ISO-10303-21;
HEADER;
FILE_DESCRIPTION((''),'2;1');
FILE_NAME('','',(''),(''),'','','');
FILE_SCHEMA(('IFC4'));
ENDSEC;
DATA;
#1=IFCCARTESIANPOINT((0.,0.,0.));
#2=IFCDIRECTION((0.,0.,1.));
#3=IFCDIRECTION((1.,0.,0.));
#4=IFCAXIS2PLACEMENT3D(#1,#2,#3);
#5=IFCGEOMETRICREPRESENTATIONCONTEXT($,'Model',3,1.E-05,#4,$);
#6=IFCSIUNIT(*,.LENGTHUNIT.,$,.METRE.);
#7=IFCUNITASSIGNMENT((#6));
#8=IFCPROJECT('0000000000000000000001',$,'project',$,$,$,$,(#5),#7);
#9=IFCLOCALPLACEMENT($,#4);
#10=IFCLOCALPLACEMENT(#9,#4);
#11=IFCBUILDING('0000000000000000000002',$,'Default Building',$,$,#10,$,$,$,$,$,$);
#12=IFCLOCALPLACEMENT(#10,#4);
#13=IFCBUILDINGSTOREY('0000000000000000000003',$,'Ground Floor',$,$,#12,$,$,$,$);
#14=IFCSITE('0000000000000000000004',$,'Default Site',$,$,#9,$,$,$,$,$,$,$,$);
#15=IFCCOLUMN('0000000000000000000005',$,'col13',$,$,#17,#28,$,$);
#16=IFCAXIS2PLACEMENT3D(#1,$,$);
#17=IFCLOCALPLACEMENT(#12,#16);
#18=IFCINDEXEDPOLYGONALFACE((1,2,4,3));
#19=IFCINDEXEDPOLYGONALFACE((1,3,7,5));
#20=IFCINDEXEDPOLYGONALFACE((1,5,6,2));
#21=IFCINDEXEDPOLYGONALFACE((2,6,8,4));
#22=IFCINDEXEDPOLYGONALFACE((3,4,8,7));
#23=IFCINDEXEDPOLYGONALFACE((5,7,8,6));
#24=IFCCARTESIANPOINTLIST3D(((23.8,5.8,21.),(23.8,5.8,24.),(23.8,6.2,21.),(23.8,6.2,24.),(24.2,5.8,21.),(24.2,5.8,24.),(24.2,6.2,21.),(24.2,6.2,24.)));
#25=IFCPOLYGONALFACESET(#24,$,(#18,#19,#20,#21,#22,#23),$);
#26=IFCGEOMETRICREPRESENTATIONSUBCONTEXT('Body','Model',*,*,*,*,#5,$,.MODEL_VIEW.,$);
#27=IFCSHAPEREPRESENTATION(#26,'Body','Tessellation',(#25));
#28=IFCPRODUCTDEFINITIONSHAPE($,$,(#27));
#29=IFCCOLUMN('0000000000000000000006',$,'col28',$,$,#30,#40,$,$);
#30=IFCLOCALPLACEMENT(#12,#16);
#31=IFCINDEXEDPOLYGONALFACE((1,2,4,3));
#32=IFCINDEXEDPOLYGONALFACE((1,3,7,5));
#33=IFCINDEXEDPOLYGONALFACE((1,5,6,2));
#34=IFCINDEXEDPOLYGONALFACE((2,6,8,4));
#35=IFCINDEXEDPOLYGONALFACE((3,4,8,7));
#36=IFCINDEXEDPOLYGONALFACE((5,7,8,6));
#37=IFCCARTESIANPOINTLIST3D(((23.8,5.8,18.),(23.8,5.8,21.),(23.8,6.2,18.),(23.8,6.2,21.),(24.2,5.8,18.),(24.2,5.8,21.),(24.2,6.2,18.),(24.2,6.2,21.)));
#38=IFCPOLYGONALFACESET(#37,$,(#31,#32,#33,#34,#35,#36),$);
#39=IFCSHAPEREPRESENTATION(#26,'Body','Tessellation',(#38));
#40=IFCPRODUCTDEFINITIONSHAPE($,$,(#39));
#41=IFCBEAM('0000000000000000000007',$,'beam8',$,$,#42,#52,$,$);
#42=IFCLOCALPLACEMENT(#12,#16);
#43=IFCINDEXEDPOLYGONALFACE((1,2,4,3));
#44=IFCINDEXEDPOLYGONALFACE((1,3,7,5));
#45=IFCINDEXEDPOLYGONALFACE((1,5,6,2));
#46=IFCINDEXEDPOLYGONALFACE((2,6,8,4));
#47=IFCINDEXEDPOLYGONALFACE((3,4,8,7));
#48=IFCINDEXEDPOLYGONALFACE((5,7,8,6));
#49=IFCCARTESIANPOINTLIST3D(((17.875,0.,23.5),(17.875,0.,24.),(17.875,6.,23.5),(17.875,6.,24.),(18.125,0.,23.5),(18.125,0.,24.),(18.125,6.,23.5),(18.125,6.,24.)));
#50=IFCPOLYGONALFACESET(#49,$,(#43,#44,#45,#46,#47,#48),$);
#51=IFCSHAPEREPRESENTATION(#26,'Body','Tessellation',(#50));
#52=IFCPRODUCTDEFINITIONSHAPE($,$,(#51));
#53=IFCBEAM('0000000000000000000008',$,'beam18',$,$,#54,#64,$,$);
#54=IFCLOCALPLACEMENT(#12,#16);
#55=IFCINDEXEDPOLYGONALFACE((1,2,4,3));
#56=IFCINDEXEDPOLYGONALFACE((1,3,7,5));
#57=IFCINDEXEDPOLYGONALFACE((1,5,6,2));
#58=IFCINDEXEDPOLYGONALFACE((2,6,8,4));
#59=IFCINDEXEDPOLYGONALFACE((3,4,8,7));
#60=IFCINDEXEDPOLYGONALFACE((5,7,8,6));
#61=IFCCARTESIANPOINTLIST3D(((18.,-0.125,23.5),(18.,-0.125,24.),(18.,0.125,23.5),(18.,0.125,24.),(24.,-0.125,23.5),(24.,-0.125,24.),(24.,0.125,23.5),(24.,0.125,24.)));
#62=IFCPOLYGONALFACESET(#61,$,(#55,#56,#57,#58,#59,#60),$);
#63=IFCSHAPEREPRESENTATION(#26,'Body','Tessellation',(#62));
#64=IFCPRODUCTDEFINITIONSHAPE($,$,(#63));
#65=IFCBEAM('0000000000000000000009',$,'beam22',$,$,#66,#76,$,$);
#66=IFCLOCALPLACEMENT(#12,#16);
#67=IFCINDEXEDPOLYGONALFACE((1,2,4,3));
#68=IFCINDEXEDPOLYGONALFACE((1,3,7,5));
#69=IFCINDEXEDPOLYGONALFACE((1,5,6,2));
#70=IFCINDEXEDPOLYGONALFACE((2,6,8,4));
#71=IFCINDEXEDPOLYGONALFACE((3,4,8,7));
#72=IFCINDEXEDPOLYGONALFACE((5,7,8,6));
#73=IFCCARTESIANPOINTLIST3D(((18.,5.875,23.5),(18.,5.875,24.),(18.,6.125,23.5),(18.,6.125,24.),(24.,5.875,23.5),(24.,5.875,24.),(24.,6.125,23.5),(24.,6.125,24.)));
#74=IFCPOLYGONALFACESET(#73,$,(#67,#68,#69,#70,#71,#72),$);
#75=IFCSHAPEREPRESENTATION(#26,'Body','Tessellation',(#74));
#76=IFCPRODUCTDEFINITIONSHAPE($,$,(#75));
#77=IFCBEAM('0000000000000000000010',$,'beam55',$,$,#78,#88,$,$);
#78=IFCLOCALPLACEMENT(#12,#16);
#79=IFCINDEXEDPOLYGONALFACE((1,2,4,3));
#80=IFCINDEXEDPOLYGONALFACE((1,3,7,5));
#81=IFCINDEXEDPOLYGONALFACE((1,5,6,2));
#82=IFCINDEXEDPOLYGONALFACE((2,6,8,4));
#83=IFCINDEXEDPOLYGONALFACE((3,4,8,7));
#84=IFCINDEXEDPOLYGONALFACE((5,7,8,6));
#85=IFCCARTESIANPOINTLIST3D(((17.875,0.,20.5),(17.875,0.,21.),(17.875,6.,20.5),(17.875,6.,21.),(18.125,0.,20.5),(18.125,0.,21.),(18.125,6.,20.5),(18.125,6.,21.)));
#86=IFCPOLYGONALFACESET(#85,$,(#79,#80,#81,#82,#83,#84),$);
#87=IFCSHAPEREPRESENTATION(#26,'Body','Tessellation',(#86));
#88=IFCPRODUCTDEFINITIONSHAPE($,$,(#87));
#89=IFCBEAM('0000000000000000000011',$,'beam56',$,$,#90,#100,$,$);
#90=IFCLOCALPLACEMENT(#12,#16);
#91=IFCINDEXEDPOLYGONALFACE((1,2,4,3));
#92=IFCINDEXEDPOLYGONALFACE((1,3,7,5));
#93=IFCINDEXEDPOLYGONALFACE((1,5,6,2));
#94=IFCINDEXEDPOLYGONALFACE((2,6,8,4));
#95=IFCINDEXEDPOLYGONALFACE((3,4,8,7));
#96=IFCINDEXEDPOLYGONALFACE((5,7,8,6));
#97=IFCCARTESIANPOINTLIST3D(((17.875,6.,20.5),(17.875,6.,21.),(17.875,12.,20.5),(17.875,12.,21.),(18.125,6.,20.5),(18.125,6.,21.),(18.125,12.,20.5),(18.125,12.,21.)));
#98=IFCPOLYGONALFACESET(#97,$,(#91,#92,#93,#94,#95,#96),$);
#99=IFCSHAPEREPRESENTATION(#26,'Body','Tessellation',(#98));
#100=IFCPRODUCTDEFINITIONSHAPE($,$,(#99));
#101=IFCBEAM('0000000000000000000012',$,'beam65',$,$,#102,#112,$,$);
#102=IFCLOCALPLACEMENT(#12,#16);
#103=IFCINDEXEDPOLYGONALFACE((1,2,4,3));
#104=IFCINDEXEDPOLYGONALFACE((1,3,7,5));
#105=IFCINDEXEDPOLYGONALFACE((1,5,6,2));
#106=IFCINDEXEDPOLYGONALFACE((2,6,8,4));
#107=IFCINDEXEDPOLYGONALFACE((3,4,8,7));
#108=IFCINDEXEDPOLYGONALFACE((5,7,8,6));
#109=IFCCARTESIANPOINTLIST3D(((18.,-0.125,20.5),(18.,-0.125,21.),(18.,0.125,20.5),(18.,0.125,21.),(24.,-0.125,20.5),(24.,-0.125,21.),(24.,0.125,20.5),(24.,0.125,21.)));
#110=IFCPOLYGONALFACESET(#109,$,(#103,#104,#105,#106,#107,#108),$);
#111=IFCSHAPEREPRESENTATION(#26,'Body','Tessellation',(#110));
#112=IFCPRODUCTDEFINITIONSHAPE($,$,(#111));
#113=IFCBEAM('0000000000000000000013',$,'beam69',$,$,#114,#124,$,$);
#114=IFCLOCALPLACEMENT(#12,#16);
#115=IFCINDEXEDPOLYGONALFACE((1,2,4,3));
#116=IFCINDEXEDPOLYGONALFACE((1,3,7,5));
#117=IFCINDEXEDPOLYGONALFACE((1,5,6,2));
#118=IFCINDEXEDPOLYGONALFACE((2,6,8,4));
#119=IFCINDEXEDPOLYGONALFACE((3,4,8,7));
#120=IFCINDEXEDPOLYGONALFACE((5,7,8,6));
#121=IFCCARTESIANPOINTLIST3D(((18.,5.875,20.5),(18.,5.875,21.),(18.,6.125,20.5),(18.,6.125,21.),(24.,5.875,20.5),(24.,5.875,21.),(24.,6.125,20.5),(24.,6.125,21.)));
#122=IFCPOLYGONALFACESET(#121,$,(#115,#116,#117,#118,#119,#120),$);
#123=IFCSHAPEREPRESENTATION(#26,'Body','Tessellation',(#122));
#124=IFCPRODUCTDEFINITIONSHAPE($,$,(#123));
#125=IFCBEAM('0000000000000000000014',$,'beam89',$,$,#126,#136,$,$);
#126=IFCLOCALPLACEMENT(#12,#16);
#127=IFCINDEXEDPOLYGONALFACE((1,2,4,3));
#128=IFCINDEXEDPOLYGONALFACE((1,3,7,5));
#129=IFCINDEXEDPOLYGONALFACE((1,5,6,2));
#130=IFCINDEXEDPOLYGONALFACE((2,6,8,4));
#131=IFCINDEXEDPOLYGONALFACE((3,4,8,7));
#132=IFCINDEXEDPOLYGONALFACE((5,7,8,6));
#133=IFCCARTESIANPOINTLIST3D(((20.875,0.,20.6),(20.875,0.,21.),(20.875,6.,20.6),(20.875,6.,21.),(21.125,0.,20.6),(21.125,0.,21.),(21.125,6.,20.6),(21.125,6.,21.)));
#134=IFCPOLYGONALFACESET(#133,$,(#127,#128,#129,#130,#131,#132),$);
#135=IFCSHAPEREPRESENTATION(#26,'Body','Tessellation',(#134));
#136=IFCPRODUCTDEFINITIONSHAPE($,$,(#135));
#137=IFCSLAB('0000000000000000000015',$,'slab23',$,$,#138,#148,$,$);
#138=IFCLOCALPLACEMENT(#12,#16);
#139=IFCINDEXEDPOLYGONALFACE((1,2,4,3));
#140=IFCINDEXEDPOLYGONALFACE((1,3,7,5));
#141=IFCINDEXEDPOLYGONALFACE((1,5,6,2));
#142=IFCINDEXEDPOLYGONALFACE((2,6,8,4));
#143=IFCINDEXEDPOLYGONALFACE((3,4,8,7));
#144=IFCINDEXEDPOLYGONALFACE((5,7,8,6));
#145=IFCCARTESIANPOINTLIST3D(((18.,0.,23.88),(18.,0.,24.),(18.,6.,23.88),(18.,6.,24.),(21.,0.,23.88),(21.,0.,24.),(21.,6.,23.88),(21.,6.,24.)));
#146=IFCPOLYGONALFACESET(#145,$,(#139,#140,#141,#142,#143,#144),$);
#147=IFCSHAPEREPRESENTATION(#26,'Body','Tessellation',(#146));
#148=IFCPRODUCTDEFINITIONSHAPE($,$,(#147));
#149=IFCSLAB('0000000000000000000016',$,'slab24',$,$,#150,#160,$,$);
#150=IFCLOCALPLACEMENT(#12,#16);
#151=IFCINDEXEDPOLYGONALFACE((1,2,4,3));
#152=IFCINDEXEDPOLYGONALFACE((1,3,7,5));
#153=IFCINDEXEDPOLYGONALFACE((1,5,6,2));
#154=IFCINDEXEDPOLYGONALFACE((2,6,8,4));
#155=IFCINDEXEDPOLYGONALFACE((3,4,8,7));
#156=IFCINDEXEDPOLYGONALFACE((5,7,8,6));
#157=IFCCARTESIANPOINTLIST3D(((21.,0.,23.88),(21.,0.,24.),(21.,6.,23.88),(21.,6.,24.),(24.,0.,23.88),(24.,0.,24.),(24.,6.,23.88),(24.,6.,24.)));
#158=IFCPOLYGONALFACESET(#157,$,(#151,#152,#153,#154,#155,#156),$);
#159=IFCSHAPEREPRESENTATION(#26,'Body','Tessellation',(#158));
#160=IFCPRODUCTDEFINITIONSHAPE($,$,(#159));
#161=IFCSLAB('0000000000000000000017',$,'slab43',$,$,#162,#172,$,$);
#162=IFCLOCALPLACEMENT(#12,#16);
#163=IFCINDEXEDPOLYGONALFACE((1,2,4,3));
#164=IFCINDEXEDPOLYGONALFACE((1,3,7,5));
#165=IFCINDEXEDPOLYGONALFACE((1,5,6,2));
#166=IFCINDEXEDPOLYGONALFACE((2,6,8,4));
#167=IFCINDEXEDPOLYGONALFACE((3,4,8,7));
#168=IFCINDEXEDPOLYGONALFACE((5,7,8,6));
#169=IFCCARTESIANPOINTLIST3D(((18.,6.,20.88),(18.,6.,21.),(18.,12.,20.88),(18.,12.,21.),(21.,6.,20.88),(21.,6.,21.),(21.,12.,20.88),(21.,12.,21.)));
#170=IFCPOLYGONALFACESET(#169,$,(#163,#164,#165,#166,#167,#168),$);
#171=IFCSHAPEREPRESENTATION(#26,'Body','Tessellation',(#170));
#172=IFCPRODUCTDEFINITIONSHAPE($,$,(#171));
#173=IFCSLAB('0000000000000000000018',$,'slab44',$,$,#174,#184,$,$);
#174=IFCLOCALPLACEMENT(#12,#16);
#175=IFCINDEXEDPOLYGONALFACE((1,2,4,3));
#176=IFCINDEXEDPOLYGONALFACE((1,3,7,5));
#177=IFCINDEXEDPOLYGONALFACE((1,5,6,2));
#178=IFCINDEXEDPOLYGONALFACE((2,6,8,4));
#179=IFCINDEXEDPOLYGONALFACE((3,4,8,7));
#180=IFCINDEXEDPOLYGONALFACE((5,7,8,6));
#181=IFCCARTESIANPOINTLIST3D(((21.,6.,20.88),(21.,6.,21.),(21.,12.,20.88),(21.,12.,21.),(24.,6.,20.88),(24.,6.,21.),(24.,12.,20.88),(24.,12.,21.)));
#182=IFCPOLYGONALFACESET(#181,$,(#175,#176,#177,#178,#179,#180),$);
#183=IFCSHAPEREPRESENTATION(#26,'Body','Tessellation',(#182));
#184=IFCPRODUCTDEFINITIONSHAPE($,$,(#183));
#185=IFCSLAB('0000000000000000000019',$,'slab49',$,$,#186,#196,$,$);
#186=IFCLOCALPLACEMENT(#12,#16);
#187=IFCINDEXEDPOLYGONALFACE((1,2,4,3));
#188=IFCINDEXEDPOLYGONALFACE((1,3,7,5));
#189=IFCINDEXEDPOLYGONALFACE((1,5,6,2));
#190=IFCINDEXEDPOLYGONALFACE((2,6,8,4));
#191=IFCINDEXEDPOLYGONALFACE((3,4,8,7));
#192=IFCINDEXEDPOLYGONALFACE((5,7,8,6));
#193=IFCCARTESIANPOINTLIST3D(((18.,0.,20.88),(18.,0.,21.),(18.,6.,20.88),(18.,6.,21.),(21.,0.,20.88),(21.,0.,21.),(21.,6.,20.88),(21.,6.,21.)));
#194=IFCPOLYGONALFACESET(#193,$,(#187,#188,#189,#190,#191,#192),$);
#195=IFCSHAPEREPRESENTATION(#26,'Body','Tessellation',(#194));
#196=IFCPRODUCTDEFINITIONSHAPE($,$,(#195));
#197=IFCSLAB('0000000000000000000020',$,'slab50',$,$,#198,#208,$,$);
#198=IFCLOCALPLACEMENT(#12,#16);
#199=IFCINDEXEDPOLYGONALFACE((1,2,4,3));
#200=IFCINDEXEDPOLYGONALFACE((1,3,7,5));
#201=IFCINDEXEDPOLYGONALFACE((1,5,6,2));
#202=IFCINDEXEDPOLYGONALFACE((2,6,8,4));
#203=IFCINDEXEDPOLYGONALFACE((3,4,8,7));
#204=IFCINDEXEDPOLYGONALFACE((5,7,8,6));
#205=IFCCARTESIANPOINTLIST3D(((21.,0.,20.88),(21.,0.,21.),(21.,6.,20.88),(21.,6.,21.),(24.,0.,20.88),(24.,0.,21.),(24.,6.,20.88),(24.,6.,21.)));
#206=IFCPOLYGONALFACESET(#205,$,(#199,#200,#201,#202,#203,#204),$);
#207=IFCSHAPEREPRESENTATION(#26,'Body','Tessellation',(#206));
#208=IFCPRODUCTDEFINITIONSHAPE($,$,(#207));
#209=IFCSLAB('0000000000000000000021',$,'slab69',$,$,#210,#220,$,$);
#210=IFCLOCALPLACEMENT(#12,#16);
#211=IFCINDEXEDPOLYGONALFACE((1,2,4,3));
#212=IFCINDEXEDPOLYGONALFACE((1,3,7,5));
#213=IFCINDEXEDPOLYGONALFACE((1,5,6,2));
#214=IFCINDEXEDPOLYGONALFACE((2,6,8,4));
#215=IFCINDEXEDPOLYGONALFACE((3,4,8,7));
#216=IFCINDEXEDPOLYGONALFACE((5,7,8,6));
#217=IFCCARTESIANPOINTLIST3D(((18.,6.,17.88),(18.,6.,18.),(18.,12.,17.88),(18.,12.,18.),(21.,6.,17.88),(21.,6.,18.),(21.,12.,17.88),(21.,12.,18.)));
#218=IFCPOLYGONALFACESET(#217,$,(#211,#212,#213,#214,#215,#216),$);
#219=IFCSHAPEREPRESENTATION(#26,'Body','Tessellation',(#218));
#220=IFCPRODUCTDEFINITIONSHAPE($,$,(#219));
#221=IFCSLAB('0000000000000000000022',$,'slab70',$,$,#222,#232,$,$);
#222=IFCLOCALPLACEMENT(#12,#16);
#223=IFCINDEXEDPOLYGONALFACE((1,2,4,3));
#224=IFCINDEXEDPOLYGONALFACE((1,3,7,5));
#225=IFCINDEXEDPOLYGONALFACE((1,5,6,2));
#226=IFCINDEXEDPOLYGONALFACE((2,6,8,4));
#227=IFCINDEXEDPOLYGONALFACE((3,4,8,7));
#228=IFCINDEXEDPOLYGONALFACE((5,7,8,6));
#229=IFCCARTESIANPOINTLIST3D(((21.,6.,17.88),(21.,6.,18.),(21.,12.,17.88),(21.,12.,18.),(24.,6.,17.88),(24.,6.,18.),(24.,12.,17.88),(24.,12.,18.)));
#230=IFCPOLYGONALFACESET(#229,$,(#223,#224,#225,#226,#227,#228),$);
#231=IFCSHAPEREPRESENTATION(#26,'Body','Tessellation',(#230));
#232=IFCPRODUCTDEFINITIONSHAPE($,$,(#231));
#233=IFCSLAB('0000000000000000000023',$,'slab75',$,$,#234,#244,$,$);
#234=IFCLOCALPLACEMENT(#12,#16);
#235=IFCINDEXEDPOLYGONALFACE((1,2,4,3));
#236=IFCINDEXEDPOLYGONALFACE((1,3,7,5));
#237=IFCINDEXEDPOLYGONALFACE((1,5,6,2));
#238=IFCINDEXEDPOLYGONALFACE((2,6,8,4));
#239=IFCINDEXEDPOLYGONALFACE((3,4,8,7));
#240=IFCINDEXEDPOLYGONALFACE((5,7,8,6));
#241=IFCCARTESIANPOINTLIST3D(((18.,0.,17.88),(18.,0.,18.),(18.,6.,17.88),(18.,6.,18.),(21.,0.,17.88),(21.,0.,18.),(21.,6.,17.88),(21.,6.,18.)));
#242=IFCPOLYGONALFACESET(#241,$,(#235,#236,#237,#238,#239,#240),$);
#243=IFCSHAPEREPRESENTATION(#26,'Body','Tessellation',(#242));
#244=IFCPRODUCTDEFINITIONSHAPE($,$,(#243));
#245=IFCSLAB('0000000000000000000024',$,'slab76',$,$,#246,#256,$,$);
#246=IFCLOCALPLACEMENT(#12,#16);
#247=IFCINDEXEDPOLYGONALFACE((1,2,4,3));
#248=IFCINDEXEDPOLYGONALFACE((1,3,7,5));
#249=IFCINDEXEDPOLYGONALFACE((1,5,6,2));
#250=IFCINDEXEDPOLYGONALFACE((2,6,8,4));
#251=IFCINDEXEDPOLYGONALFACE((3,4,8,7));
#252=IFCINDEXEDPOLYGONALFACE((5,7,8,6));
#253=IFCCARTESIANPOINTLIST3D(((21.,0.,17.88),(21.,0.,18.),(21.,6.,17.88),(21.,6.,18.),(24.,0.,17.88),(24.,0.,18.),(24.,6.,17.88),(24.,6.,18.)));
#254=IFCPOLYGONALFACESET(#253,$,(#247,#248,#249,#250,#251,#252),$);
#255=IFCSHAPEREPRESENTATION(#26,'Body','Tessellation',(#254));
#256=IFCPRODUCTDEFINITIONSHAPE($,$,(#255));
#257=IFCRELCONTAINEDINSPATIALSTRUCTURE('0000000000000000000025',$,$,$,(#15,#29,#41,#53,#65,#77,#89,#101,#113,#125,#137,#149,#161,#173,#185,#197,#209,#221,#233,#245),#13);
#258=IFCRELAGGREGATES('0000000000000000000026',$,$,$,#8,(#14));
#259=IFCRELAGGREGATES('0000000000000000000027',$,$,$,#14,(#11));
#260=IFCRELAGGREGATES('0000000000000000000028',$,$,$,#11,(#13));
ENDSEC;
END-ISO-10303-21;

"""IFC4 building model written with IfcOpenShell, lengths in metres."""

from ifc_helpers import new_model, si_unit, frame, origin_with_axes, place, context, subcontext, project, spatial, indexed_curve, outline, extrude, element, save


model = new_model("IFC4")

# Units and contexts
model_context = context("Model", 3, precision=1e-05, world=origin_with_axes())
body_context = subcontext(model_context, "Body", "Model", "MODEL_VIEW")
ifc_project = project(units=[si_unit("LENGTHUNIT", "METRE")], contexts=[model_context])

# Site, building, storey
site_placement = place(None, origin_with_axes())
site = spatial("IfcSite", under=ifc_project, at=site_placement, Name="Default Site")
building_placement = place(site_placement, origin_with_axes())
building = spatial("IfcBuilding", under=site, at=building_placement, Name="Default Building")
storey_placement = place(building_placement, origin_with_axes())
storey = spatial("IfcBuildingStorey", under=building, at=storey_placement, Name="Ground Floor")

# Columns
for number, where, z_axis, x_axis, name in (
    (1, (23.8, 5.8, 21.0), (0.0, 0.0, 1.0), (1.0, 0.0, 0.0), "col13"),
    (2, (23.8, 5.8, 18.0), (0.0, 0.0, 1.0), (1.0, 0.0, 0.0), "col28"),
):
    element("IfcColumn", number, at=place(storey_placement, frame(where, z_axis=z_axis, x_axis=x_axis)), inside=storey, Name=name, context=body_context, shape_type="SweptSolid", body=[
        extrude(outline(indexed_curve([(0.0, 0.0), (0.0, 0.4), (0.4, 0.4), (0.4, 0.0), (0.0, 0.0)], self_intersect=False)), origin_with_axes(), (0.0, 0.0, 1.0), 3.0),
    ])

# Beams
for number, where, z_axis, x_axis, name in (
    (3, (18.125, 0.0, 23.5), (0.0, 0.0, 1.0), (0.0, 1.0, 0.0), "beam8"),
    (4, (18.0, -0.125, 23.5), (0.0, 0.0, 1.0), (1.0, 0.0, 0.0), "beam18"),
    (5, (18.0, 5.875, 23.5), (0.0, 0.0, 1.0), (1.0, 0.0, 0.0), "beam22"),
    (6, (18.125, 0.0, 20.5), (0.0, 0.0, 1.0), (0.0, 1.0, 0.0), "beam55"),
    (7, (18.125, 6.0, 20.5), (0.0, 0.0, 1.0), (0.0, 1.0, 0.0), "beam56"),
    (8, (18.0, -0.125, 20.5), (0.0, 0.0, 1.0), (1.0, 0.0, 0.0), "beam65"),
    (9, (18.0, 5.875, 20.5), (0.0, 0.0, 1.0), (1.0, 0.0, 0.0), "beam69"),
):
    element("IfcBeam", number, at=place(storey_placement, frame(where, z_axis=z_axis, x_axis=x_axis)), inside=storey, Name=name, context=body_context, shape_type="SweptSolid", body=[
        extrude(outline(indexed_curve([(0.0, 0.0), (0.0, 0.25), (6.0, 0.25), (6.0, 0.0), (0.0, 0.0)], self_intersect=False)), origin_with_axes(), (0.0, 0.0, 1.0), 0.5),
    ])
beam_placement = place(storey_placement, frame((20.875, 6.0, 20.6), z_axis=(0.0, 0.0, 1.0), x_axis=(0.0, -1.0, 0.0)))
element("IfcBeam", 10, at=beam_placement, inside=storey, Name="beam89", context=body_context, shape_type="SweptSolid", body=[
    extrude(outline(indexed_curve([(0.0, 0.0), (0.0, 0.25), (6.0, 0.25), (6.0, 0.0), (0.0, 0.0)], self_intersect=False)), origin_with_axes(), (0.0, 0.0, 1.0), 0.4),
])

# Slabs
for number, where, z_axis, x_axis, name in (
    (11, (18.0, 0.0, 23.88), (0.0, 0.0, 1.0), (1.0, 0.0, 0.0), "slab23"),
    (12, (21.0, 0.0, 23.88), (0.0, 0.0, 1.0), (1.0, 0.0, 0.0), "slab24"),
    (13, (18.0, 6.0, 20.88), (0.0, 0.0, 1.0), (1.0, 0.0, 0.0), "slab43"),
    (14, (21.0, 6.0, 20.88), (0.0, 0.0, 1.0), (1.0, 0.0, 0.0), "slab44"),
    (15, (18.0, 0.0, 20.88), (0.0, 0.0, 1.0), (1.0, 0.0, 0.0), "slab49"),
    (16, (21.0, 0.0, 20.88), (0.0, 0.0, 1.0), (1.0, 0.0, 0.0), "slab50"),
    (17, (18.0, 6.0, 17.88), (0.0, 0.0, 1.0), (1.0, 0.0, 0.0), "slab69"),
    (18, (21.0, 6.0, 17.88), (0.0, 0.0, 1.0), (1.0, 0.0, 0.0), "slab70"),
    (19, (18.0, 0.0, 17.88), (0.0, 0.0, 1.0), (1.0, 0.0, 0.0), "slab75"),
    (20, (21.0, 0.0, 17.88), (0.0, 0.0, 1.0), (1.0, 0.0, 0.0), "slab76"),
):
    element("IfcSlab", number, at=place(storey_placement, frame(where, z_axis=z_axis, x_axis=x_axis)), inside=storey, Name=name, context=body_context, shape_type="SweptSolid", body=[
        extrude(outline(indexed_curve([(0.0, 0.0), (0.0, 6.0), (3.0, 6.0), (3.0, 0.0), (0.0, 0.0)], self_intersect=False)), origin_with_axes(), (0.0, 0.0, 1.0), 0.12),
    ])

save(model, "model.ifc")
